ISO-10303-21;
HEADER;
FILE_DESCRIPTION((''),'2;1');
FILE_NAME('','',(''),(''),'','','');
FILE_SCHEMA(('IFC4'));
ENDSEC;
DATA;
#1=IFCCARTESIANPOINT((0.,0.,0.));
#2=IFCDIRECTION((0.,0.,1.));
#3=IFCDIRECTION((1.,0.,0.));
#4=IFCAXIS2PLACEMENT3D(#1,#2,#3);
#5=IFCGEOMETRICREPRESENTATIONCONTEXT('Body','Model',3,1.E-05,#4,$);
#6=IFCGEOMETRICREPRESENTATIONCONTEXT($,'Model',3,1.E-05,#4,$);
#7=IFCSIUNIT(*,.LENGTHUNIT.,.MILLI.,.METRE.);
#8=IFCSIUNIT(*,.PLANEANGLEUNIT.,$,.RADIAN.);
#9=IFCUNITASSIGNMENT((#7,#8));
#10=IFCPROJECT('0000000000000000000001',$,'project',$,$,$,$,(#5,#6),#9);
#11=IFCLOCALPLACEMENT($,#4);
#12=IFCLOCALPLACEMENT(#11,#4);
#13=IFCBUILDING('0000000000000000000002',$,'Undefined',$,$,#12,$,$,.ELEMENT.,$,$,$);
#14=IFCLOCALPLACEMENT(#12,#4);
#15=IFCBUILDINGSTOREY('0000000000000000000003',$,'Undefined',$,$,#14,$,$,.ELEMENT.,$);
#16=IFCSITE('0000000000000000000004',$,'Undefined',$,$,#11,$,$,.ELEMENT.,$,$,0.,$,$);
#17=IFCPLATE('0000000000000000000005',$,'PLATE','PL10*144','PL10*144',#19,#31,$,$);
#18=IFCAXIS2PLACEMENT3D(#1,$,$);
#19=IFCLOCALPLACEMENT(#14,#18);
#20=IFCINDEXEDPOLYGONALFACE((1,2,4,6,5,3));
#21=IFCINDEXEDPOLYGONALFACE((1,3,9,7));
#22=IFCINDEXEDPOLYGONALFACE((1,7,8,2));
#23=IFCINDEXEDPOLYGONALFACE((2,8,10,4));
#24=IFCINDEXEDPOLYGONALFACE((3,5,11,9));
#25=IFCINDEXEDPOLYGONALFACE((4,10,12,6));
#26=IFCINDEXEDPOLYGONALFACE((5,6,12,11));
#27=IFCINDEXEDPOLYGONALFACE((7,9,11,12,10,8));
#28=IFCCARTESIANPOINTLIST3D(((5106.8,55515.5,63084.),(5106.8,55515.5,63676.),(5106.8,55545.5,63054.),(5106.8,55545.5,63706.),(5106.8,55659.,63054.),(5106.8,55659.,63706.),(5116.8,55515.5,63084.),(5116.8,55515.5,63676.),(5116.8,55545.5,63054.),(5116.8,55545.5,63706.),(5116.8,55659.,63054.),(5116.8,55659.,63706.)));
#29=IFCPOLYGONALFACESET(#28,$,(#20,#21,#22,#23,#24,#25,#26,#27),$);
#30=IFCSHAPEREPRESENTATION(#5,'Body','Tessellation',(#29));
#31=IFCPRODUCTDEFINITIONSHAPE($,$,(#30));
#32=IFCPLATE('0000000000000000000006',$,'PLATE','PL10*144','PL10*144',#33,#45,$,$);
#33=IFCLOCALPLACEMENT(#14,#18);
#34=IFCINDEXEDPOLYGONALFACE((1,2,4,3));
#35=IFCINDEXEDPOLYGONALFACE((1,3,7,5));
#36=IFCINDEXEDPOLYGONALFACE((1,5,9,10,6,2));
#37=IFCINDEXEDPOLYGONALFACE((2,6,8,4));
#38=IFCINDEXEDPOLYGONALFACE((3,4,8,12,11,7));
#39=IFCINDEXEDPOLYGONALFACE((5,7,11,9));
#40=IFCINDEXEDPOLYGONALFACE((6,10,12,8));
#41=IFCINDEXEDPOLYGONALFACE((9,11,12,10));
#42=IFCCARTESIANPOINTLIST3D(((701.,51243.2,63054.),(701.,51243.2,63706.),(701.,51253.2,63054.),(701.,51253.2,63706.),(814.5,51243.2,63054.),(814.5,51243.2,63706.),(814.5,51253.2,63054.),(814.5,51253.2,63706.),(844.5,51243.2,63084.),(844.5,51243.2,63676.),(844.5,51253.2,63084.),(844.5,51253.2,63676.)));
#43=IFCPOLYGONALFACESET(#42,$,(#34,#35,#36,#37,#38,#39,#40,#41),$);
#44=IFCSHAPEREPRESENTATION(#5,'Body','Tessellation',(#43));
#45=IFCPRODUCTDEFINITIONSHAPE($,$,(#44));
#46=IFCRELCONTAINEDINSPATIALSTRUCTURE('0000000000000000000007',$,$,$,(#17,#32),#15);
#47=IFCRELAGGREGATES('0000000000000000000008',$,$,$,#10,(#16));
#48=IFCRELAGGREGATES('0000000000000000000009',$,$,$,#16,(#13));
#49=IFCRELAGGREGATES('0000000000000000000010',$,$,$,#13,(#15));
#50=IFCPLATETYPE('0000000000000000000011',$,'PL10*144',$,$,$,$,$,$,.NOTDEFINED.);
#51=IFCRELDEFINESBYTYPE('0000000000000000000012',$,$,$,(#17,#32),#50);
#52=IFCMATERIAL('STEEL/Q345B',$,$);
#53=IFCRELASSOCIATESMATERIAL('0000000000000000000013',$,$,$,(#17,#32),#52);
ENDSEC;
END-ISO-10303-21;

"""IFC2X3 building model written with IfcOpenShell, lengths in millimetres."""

from ifc_helpers import new_model, si_unit, frame, origin_with_axes, place, context, project, spatial, polyline, outline, extrude, material, type_object, element, save


model = new_model("IFC2X3")

# Units and contexts
model_context_1 = context("Model", 3, precision=1e-05, world=origin_with_axes(), identifier="Body")
model_context_2 = context("Model", 3, precision=1e-05, world=origin_with_axes())
ifc_project = project(units=[si_unit("LENGTHUNIT", "METRE", prefix="MILLI"), si_unit("PLANEANGLEUNIT", "RADIAN")], contexts=[model_context_1, model_context_2])

# Site, building, storey
site_placement = place(None, origin_with_axes())
site = spatial("IfcSite", under=ifc_project, at=site_placement, Name="Undefined", CompositionType="ELEMENT", RefElevation=0.0)
building_placement = place(site_placement, origin_with_axes())
building = spatial("IfcBuilding", under=site, at=building_placement, Name="Undefined", CompositionType="ELEMENT")
storey_placement = place(building_placement, origin_with_axes())
storey = spatial("IfcBuildingStorey", under=building, at=storey_placement, Name="Undefined", CompositionType="ELEMENT")

# Shared definitions
ifc_material_1 = material(Name="STEEL/Q345B")

# Plates
plate_type_1 = type_object("IfcPlateType", Name="PL10*144", PredefinedType="NOTDEFINED")
for number, where, z_axis, x_axis, name in (
    (1, (5111.8, 55515.5, 63054.0), (1.0, 0.0, 0.0), (0.0, 1.0, 0.0), "PLATE"),
    (2, (844.5, 51248.2, 63054.0), (0.0, 1.0, 0.0), (-1.0, 0.0, 0.0), "PLATE"),
):
    element("IfcPlate", number, at=place(storey_placement, frame(where, z_axis=z_axis, x_axis=x_axis)), inside=storey, type_object=plate_type_1, material=ifc_material_1, Name=name, Description="PL10*144", ObjectType="PL10*144", context=model_context_1, shape_type="SweptSolid", body=[
        extrude(outline(polyline([(0.0, 30.0), (30.0, 0.0), (143.5, 0.0), (143.5, 652.0), (30.0, 652.0), (0.0, 622.0), (0.0, 30.0)])), frame((0.0, 0.0, -5.0), z_axis=(0.0, 0.0, 1.0), x_axis=(1.0, 0.0, 0.0)), (0.0, 0.0, 1.0), 10.0),
    ])

save(model, "model.ifc")
